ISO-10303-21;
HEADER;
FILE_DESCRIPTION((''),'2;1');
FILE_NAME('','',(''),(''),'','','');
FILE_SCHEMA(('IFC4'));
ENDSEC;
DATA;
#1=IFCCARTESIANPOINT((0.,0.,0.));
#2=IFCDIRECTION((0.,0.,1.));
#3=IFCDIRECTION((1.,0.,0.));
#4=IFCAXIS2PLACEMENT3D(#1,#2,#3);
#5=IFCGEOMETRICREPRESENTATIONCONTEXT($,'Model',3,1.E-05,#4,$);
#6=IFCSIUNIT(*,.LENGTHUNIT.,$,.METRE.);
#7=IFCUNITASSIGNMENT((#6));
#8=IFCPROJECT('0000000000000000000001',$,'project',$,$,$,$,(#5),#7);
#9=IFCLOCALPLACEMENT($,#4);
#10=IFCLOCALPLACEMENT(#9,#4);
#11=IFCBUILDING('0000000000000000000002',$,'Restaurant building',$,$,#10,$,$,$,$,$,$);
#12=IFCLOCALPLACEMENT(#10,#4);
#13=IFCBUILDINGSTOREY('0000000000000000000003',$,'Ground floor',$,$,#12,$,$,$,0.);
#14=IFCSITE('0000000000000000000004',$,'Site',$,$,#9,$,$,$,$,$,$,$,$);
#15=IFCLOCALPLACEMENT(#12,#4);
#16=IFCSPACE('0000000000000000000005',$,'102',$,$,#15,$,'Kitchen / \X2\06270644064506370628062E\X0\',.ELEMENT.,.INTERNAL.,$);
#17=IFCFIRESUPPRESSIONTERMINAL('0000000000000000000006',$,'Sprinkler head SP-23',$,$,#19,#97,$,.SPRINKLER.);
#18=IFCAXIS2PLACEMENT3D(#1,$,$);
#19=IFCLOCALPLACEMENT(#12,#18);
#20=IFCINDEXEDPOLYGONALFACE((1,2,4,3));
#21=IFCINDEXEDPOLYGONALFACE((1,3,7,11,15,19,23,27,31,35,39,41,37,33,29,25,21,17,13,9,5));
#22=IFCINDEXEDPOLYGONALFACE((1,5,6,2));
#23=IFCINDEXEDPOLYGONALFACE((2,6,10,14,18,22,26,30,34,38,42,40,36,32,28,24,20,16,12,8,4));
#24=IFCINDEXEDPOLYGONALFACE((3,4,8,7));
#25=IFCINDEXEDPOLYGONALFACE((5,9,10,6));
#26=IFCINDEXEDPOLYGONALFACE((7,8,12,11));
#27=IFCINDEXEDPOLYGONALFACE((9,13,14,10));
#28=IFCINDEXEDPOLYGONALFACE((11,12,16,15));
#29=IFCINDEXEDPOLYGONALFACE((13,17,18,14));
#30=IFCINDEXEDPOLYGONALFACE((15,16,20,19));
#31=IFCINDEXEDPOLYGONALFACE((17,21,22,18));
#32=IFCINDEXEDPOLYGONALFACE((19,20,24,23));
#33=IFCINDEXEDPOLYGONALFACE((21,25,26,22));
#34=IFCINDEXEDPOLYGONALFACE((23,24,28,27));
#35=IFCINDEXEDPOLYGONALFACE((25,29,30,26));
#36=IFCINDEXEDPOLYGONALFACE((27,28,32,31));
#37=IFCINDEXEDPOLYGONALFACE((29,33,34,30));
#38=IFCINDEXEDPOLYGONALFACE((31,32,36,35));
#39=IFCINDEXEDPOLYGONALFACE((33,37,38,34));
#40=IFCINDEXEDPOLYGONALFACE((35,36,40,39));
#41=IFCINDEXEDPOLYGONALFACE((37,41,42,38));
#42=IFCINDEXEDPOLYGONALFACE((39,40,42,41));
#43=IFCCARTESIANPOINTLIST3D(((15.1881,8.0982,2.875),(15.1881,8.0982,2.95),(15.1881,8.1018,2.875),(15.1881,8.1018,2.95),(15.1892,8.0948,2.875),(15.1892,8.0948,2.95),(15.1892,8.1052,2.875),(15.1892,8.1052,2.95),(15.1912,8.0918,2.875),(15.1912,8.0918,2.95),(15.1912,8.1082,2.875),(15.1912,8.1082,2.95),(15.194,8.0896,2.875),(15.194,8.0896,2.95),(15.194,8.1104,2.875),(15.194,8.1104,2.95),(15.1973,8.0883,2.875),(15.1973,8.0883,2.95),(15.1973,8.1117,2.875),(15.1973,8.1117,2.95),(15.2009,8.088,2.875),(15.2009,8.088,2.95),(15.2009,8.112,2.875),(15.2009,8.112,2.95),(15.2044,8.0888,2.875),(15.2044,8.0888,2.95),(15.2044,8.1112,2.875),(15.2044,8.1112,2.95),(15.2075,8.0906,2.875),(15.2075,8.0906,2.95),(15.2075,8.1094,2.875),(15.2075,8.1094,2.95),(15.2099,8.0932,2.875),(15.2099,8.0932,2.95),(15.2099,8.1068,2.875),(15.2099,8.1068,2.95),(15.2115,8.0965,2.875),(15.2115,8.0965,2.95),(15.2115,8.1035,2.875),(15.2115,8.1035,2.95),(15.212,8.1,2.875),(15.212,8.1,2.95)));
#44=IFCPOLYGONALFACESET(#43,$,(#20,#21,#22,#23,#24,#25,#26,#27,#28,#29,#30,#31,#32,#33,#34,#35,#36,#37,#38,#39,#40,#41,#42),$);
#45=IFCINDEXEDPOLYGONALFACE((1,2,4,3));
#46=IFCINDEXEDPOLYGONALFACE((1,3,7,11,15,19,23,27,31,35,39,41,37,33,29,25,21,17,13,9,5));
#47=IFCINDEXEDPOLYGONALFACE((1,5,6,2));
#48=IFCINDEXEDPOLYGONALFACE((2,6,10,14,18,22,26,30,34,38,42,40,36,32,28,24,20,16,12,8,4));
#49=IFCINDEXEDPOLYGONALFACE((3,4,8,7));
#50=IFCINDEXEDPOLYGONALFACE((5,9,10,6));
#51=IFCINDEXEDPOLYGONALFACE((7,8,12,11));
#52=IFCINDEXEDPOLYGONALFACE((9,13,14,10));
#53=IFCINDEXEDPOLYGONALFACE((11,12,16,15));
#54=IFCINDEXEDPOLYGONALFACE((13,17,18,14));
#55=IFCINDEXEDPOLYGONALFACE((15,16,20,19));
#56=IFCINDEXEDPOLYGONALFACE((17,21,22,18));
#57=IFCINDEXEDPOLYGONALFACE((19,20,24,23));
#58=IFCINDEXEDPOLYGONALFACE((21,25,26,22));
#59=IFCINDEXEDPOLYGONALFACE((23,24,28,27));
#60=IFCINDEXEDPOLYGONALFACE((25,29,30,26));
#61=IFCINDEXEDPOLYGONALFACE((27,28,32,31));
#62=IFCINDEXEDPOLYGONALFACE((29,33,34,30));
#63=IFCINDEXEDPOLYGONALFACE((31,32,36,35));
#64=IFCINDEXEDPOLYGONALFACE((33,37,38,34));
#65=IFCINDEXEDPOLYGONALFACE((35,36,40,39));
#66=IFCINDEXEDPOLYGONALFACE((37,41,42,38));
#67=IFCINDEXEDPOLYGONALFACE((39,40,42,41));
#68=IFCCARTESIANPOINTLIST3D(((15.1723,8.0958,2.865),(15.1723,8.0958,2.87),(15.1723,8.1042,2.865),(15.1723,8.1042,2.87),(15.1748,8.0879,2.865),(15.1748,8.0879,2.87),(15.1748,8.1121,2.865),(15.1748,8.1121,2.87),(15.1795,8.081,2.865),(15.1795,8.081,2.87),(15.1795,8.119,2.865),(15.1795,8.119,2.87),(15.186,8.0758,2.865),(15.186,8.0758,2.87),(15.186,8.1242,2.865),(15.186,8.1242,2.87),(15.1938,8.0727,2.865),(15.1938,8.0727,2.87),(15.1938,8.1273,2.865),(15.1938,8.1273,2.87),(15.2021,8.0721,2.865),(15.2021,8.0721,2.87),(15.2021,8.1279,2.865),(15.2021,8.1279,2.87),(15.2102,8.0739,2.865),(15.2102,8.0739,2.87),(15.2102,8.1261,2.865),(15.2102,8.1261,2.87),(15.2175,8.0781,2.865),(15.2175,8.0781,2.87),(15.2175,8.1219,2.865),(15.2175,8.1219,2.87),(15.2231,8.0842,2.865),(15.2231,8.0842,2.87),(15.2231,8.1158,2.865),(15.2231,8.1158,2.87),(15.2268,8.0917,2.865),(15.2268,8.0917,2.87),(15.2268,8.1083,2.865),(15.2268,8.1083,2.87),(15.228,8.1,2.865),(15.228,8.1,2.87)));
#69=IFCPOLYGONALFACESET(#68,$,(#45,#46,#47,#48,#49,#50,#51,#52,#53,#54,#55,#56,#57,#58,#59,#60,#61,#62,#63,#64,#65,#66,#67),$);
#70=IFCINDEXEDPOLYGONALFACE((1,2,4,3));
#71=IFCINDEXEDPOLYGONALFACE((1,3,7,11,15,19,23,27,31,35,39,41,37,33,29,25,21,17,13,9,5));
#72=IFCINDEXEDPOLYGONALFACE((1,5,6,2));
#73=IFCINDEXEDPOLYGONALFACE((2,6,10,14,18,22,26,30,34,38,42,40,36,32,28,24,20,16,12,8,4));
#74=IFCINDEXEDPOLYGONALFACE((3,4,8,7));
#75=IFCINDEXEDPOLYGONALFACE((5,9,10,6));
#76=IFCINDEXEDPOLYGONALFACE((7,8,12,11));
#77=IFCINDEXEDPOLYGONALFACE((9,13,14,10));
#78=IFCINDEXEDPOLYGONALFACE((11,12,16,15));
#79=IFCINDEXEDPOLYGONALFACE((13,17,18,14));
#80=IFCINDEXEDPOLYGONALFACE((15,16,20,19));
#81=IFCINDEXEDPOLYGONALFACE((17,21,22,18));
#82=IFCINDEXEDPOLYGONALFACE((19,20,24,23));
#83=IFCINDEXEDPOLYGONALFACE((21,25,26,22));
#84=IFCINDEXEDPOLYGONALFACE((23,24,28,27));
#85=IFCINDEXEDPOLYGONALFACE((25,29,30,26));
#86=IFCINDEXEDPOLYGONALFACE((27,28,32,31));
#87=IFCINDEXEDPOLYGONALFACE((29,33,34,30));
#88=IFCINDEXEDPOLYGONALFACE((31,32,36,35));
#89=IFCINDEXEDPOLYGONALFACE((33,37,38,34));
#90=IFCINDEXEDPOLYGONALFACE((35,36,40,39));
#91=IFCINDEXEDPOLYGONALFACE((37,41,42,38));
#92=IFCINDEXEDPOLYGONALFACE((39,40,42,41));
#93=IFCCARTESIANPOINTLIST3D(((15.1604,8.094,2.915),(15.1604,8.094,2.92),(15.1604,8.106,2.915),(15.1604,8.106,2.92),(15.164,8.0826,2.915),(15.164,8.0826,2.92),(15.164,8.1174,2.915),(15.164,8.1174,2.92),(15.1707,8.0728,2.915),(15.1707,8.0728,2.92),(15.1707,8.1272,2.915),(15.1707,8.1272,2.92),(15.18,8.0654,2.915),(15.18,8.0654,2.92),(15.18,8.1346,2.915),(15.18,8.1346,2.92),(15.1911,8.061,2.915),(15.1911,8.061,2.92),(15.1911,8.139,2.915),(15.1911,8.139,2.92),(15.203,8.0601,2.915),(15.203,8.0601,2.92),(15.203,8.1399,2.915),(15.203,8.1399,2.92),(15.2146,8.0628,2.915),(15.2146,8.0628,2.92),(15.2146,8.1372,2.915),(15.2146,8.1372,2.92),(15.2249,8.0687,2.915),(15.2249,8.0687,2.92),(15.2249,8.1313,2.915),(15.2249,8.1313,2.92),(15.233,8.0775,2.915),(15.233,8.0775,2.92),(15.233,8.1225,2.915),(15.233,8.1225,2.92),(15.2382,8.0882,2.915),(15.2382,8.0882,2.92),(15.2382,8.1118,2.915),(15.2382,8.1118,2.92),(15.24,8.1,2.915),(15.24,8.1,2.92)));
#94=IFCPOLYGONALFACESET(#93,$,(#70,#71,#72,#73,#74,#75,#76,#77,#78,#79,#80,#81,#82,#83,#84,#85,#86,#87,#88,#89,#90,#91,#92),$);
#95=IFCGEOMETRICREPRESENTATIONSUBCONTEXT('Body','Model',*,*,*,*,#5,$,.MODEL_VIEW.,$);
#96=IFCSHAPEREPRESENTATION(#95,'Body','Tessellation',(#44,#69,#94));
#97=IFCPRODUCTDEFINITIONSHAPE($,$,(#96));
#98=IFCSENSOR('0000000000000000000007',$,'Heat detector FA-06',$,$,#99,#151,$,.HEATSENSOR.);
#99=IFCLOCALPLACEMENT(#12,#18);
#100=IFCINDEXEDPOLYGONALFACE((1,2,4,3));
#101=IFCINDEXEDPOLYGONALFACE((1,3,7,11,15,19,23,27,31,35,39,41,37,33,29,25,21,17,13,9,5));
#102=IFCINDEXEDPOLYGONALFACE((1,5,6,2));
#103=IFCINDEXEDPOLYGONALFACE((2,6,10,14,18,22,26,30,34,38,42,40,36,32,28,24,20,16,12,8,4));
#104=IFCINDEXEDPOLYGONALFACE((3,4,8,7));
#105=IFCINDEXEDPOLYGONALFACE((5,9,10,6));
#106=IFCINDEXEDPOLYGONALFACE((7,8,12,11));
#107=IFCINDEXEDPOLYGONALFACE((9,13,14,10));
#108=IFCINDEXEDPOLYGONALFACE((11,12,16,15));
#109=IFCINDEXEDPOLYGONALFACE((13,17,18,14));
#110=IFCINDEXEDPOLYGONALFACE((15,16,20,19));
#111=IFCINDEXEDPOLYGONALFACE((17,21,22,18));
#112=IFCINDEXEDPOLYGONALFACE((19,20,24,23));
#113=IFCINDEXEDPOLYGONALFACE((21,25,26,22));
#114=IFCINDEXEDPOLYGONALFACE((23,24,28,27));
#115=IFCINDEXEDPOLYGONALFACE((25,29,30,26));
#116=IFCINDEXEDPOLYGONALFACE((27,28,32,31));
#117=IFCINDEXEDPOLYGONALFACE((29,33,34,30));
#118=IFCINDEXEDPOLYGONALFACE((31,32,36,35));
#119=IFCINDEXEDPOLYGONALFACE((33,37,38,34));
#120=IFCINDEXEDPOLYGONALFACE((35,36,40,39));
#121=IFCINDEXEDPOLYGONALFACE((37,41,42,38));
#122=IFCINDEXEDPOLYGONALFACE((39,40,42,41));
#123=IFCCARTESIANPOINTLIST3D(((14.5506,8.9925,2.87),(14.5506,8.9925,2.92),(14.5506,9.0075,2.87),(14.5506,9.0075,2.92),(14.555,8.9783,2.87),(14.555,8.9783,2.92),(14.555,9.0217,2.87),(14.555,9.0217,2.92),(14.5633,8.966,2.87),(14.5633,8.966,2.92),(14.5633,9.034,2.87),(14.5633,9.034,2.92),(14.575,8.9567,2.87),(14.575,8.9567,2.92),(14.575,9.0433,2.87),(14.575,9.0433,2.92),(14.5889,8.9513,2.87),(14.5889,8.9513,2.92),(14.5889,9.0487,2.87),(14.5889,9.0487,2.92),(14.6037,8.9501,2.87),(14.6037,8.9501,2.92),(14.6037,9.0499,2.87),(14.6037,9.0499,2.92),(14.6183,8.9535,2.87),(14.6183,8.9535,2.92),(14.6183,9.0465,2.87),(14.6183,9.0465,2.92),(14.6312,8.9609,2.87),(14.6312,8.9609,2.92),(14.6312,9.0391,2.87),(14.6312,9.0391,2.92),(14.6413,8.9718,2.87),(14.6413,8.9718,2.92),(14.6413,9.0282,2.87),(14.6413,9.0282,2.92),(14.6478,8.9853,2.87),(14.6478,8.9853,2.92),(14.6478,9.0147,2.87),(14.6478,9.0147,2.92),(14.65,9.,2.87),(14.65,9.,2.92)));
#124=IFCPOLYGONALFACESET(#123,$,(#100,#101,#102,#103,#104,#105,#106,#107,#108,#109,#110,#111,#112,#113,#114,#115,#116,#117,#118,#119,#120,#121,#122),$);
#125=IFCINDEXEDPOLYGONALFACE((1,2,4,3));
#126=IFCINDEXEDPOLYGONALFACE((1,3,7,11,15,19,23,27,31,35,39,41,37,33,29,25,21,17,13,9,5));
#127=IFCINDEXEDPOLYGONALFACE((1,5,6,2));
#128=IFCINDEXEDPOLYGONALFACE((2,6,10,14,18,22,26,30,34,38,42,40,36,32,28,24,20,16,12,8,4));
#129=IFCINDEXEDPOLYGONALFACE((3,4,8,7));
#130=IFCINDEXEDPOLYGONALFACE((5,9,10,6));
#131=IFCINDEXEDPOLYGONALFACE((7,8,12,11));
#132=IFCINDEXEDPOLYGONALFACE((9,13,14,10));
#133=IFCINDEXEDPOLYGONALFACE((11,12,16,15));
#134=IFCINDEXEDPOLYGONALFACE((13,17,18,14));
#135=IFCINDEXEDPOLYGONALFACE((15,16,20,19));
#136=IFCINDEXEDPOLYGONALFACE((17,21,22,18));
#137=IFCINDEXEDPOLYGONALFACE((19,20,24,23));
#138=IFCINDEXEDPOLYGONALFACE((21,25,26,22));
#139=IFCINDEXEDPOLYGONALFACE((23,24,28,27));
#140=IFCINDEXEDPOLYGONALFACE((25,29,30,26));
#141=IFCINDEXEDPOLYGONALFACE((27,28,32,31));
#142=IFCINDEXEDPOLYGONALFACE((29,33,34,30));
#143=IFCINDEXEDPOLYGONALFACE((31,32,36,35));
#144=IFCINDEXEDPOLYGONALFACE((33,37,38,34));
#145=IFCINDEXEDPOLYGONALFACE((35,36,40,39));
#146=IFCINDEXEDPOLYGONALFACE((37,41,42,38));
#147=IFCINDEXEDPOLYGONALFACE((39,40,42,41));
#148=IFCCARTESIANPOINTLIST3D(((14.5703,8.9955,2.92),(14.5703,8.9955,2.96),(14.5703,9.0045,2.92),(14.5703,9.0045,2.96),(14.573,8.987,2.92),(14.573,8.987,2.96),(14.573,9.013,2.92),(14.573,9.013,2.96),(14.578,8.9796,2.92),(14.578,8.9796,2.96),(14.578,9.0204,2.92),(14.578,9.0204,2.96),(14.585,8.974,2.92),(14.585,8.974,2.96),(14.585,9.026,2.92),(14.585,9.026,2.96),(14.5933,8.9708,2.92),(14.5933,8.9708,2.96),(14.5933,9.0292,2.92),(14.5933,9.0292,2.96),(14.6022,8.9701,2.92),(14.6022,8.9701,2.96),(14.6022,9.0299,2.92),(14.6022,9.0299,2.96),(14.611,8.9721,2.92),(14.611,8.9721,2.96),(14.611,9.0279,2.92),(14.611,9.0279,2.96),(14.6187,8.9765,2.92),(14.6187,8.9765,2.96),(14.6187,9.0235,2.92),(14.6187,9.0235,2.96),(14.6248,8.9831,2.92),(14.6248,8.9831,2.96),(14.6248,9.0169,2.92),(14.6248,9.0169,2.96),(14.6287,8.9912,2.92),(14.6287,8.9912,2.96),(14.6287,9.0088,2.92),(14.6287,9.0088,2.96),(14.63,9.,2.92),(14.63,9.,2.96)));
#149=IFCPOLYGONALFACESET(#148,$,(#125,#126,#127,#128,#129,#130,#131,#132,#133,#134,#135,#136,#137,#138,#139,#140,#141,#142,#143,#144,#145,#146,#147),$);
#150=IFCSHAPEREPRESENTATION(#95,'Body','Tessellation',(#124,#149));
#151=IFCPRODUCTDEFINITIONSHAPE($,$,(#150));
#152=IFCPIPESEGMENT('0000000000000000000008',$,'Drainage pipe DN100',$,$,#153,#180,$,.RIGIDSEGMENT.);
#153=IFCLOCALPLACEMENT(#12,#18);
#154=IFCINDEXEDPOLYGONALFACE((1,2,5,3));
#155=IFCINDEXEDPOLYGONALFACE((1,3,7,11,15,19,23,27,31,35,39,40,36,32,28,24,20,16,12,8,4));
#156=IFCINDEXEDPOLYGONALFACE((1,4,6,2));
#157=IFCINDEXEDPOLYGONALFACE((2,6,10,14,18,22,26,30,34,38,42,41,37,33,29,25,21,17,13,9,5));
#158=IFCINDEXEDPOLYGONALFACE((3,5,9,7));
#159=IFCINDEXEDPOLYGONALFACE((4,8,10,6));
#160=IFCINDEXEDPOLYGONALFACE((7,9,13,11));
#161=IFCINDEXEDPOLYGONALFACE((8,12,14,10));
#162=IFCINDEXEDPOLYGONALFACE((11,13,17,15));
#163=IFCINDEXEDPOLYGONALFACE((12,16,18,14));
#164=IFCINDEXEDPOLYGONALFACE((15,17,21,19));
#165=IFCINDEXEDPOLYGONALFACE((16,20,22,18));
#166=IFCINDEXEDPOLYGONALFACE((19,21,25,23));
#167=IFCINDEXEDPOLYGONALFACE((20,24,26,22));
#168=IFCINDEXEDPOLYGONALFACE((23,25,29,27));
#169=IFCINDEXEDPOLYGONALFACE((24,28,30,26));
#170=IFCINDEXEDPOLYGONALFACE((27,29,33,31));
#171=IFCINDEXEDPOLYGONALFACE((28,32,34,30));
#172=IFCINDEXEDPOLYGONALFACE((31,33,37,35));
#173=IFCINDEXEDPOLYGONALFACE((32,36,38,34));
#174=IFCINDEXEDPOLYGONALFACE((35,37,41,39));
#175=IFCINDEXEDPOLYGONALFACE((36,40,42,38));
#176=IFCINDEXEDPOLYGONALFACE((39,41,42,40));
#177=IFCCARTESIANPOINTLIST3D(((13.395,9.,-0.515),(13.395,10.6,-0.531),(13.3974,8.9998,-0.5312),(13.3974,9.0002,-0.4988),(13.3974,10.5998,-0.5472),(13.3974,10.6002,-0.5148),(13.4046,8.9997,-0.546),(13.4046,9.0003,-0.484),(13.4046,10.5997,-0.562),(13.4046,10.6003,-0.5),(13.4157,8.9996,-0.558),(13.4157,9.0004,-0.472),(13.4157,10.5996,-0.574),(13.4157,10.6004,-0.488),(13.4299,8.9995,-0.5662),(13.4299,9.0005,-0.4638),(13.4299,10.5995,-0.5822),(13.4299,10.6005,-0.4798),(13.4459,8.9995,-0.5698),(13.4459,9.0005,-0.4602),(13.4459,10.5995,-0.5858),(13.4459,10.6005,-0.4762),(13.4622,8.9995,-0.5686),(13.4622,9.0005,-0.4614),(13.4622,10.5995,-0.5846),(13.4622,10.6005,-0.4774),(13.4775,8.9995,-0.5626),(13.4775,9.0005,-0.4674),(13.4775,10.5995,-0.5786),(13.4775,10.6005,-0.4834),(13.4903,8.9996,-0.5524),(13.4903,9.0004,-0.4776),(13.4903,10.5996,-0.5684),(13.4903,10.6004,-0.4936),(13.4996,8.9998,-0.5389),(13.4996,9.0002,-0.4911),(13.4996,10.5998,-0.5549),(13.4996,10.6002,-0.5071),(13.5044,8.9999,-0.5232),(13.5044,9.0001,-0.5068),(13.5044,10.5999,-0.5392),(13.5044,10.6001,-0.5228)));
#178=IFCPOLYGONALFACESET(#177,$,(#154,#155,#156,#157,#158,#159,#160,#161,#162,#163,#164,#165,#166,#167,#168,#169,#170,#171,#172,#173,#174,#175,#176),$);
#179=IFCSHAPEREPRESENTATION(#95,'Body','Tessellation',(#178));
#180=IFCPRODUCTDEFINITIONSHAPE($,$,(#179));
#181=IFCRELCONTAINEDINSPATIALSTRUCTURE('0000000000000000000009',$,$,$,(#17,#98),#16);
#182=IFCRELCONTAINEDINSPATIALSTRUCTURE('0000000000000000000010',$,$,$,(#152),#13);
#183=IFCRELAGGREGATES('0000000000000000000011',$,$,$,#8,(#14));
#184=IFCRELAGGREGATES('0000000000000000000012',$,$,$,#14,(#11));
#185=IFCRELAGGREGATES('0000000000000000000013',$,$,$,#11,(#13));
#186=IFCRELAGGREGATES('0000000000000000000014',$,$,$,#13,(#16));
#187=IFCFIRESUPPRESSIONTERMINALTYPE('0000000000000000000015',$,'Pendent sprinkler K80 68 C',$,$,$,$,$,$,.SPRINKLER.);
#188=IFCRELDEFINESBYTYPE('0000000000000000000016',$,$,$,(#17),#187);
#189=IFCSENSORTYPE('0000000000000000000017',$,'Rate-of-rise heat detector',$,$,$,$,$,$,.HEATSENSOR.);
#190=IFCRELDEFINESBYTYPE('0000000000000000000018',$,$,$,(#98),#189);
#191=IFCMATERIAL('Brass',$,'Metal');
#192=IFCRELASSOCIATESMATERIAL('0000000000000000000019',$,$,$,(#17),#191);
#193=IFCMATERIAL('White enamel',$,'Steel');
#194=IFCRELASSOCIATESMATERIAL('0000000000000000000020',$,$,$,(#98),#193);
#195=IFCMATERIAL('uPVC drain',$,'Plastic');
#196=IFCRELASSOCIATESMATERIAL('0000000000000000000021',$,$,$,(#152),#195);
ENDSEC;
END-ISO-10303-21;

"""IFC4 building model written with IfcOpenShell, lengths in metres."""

from ifc_helpers import new_model, si_unit, frame, origin, origin_with_axes, origin_2d, place, context, subcontext, project, spatial, circle, extrude, source, transform, mapped, material, type_object, type_shapes, element, save


model = new_model("IFC4")

# Units and contexts
model_context = context("Model", 3, precision=1e-05, world=origin_with_axes())
body_context = subcontext(model_context, "Body", "Model", "MODEL_VIEW")
ifc_project = project(units=[si_unit("LENGTHUNIT", "METRE")], contexts=[model_context])

# Site, building, storey
site_placement = place(None, origin_with_axes())
site = spatial("IfcSite", under=ifc_project, at=site_placement, Name="Site")
building_placement = place(site_placement, origin_with_axes())
building = spatial("IfcBuilding", under=site, at=building_placement, Name="Restaurant building")
storey_placement = place(building_placement, origin_with_axes())
storey = spatial("IfcBuildingStorey", under=building, at=storey_placement, Name="Ground floor", Elevation=0.0)

# Shared definitions
ifc_material_1 = material(Name="White enamel", Category="Steel")

# Shared definitions
space_placement = place(storey_placement, origin_with_axes())
space = spatial("IfcSpace", under=storey, at=space_placement, Name="102", LongName="Kitchen / المطبخ", CompositionType="ELEMENT", PredefinedType="INTERNAL")

# Fire suppression terminal
ifc_material_2 = material(Name="Brass", Category="Metal")
fire_suppression_terminal_type = type_object("IfcFireSuppressionTerminalType", Name="Pendent sprinkler K80 68 C", PredefinedType="SPRINKLER")
shared_shape_1 = source(origin(), body_context, "Body", "SweptSolid", [
    extrude(circle(Radius=0.012, at=origin_2d()), frame((0.0, 0.0, -0.075)), (0.0, 0.0, 1.0), 0.075),
    extrude(circle(Radius=0.028, at=origin_2d()), frame((0.0, 0.0, -0.085)), (0.0, 0.0, 1.0), 0.005),
    extrude(circle(Radius=0.04, at=origin_2d()), frame((0.0, 0.0, -0.035)), (0.0, 0.0, 1.0), 0.005),
])
type_shapes(fire_suppression_terminal_type, [shared_shape_1])
for number, where, name in (
    (1, (15.2, 8.1, 2.95), "Sprinkler head SP-23"),
):
    element("IfcFireSuppressionTerminal", number, at=place(storey_placement, frame(where)), inside=space, type_object=fire_suppression_terminal_type, material=ifc_material_2, Name=name, PredefinedType="SPRINKLER", context=body_context, shape_type="MappedRepresentation", body=[
        mapped(shared_shape_1, transform((0.0, 0.0, 0.0))),
    ])

# Sensor
sensor_type = type_object("IfcSensorType", Name="Rate-of-rise heat detector", PredefinedType="HEATSENSOR")
shared_shape_2 = source(origin(), body_context, "Body", "SweptSolid", [
    extrude(circle(Radius=0.05, at=origin_2d()), frame((0.0, 0.0, -0.09)), (0.0, 0.0, 1.0), 0.05),
    extrude(circle(Radius=0.03, at=origin_2d()), frame((0.0, 0.0, -0.04)), (0.0, 0.0, 1.0), 0.04),
])
type_shapes(sensor_type, [shared_shape_2])
sensor_placement = place(storey_placement, frame((14.6, 9.0, 2.96)))
element("IfcSensor", 2, at=sensor_placement, inside=space, type_object=sensor_type, material=ifc_material_1, Name="Heat detector FA-06", PredefinedType="HEATSENSOR", context=body_context, shape_type="MappedRepresentation", body=[
    mapped(shared_shape_2, transform((0.0, 0.0, 0.0))),
])

# Pipe segment
ifc_material_3 = material(Name="uPVC drain", Category="Plastic")
pipe_segment_1_placement = place(storey_placement, frame((13.45, 9.0, -0.515)))
element("IfcPipeSegment", 3, at=pipe_segment_1_placement, inside=storey, material=ifc_material_3, Name="Drainage pipe DN100", PredefinedType="RIGIDSEGMENT", context=body_context, shape_type="SweptSolid", body=[
    extrude(circle(Radius=0.055, at=origin_2d()), frame((0.0, 0.0, 0.0), z_axis=(0.0, 0.99995, -0.009999), x_axis=(-1.0, 0.0, 0.0)), (0.0, 0.0, 1.0), 1.6001),
])

save(model, "model.ifc")
